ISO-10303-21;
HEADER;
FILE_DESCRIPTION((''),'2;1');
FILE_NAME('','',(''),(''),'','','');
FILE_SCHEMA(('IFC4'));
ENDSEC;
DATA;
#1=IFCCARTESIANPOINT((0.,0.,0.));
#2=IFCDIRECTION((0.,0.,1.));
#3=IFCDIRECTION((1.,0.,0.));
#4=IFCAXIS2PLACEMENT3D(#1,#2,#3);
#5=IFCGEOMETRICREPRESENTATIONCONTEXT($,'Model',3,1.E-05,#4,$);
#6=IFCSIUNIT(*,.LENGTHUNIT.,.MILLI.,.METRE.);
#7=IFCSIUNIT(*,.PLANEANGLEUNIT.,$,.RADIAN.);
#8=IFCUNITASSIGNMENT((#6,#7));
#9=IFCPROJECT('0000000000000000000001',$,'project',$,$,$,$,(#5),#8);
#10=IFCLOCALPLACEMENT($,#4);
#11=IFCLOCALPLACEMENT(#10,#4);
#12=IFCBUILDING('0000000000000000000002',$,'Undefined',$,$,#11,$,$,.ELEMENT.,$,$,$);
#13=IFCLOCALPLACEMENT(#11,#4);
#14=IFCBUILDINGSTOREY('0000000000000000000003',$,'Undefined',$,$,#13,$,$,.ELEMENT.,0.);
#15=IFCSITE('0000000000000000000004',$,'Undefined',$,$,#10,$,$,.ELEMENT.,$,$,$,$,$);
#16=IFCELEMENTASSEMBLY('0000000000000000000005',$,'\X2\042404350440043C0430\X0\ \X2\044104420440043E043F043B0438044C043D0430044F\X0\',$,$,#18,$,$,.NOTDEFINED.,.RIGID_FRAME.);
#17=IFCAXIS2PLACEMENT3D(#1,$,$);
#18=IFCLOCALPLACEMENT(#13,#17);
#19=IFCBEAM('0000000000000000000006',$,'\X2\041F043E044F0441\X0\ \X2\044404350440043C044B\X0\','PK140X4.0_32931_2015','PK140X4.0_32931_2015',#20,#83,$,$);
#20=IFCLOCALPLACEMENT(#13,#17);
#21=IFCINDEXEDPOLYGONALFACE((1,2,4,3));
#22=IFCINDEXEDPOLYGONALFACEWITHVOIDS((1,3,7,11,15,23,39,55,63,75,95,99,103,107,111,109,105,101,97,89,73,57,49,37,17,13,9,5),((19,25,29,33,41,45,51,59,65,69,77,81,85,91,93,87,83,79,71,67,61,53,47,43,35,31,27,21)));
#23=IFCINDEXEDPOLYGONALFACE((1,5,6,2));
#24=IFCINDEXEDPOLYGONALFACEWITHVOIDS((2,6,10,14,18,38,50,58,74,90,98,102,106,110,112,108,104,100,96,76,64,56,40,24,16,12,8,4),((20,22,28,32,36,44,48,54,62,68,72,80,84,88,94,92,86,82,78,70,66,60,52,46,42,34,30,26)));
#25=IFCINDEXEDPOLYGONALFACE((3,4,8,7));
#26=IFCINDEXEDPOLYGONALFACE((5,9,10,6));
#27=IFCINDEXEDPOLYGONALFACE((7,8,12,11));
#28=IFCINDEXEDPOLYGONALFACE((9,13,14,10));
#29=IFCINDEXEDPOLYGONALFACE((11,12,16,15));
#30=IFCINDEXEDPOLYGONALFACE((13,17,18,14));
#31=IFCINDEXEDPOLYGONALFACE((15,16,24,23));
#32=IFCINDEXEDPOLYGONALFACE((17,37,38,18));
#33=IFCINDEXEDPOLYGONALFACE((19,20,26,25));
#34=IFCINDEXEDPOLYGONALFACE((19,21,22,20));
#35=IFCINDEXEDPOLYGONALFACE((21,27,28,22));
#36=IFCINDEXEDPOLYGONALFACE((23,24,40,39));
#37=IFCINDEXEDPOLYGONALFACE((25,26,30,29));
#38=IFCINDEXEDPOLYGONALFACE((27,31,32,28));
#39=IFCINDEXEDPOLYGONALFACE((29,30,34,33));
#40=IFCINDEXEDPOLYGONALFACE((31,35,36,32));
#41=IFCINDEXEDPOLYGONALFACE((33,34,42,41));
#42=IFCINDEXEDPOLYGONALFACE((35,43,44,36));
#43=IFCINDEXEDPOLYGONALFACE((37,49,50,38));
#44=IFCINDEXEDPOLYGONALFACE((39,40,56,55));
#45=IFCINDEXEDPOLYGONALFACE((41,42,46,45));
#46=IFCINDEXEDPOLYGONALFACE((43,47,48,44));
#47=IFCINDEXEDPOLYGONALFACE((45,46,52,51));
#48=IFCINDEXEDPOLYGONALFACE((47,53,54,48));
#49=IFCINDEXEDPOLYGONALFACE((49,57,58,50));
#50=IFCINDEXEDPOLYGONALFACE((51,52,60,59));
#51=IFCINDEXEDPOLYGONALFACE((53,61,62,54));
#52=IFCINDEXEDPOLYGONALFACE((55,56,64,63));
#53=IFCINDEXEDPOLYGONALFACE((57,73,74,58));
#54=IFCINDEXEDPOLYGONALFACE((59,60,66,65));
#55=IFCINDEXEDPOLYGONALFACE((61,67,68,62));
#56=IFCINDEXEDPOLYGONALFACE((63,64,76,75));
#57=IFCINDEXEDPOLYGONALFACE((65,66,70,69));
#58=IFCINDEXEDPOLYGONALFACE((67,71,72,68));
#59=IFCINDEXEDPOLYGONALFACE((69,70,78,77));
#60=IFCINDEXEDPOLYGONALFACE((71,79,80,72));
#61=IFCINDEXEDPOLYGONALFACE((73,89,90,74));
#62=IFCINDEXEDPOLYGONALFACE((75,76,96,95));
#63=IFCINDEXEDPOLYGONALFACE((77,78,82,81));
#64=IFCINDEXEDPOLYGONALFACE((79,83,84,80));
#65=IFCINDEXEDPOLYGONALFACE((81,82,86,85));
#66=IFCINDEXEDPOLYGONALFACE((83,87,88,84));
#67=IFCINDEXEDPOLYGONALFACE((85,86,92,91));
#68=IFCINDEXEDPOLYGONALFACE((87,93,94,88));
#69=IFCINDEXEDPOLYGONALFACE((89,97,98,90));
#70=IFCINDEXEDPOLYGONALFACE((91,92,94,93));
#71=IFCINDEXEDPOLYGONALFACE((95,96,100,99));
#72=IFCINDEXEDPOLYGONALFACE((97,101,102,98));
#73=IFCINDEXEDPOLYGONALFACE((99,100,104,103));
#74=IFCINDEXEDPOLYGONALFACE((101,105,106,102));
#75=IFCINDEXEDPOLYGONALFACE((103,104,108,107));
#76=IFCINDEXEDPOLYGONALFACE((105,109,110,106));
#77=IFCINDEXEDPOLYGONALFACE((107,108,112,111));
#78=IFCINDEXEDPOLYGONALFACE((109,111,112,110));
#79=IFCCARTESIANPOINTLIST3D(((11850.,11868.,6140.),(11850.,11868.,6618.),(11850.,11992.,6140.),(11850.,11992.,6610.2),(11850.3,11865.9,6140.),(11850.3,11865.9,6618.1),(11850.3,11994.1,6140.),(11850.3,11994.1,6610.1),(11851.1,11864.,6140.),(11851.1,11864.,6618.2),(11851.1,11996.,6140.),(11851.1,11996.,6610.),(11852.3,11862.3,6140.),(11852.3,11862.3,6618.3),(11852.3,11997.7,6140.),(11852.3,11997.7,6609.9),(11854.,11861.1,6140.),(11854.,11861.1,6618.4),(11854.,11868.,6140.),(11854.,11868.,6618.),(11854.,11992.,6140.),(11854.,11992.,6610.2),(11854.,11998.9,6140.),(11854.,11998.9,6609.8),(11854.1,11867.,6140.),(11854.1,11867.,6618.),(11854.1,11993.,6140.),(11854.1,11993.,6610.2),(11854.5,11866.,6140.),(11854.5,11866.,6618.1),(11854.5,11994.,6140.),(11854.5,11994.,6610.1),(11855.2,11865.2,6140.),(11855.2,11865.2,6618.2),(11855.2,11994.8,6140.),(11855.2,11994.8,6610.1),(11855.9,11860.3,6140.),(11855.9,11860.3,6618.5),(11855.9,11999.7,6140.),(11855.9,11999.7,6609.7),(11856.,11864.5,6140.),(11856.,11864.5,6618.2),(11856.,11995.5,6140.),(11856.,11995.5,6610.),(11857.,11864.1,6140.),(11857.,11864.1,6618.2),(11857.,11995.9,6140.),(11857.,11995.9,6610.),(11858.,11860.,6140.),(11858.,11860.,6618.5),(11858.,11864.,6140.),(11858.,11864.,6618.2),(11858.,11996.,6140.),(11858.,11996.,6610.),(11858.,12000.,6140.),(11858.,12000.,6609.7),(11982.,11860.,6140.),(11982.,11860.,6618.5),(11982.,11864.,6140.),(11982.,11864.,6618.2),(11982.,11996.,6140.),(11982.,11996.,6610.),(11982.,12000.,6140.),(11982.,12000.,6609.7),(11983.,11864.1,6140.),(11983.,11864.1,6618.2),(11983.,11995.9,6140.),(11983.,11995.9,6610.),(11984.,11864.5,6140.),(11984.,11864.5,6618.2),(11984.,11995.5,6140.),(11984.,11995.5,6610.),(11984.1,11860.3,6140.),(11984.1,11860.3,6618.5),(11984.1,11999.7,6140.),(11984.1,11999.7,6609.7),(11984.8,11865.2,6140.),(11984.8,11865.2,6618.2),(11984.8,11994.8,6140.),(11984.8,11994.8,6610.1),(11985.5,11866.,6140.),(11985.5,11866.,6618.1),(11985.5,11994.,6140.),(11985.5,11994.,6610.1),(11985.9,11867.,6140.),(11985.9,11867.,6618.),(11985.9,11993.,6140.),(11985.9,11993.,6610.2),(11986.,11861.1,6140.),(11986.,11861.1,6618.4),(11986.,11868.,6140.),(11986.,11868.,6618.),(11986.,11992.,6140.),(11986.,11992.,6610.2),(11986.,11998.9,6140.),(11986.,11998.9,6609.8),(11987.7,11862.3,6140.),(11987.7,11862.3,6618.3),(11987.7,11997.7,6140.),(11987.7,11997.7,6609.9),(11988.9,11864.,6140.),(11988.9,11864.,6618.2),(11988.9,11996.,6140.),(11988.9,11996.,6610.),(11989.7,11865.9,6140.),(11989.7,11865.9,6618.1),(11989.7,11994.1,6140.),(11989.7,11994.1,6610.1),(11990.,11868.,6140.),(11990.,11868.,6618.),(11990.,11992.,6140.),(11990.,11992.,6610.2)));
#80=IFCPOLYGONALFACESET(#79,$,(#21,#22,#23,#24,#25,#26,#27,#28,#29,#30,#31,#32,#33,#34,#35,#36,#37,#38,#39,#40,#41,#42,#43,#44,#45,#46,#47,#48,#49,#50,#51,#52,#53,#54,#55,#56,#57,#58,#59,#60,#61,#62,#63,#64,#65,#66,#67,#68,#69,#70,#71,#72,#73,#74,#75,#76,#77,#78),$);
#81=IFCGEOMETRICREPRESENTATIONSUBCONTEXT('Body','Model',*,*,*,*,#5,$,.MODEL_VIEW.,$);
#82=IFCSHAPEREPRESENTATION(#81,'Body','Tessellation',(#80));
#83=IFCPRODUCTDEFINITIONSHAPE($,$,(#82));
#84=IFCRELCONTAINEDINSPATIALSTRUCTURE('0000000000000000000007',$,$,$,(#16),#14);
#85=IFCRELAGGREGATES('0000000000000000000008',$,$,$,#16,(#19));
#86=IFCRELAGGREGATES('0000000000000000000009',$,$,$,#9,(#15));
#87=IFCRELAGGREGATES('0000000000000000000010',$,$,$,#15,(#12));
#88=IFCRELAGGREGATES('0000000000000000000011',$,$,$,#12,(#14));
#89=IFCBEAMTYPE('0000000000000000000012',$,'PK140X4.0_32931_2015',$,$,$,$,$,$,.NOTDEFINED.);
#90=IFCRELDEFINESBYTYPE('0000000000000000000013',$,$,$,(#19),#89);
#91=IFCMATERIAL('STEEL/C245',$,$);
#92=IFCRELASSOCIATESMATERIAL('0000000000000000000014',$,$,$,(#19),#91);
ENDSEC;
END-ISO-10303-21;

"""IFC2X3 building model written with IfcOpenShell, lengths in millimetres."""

from ifc_helpers import new_model, si_unit, frame, origin_with_axes, origin_2d_with_axis, place, context, subcontext, project, spatial, hollow_rectangle, extrude, clip, halfspace, material, type_object, element, aggregate, save


model = new_model("IFC2X3")

# Units and contexts
model_context = context("Model", 3, precision=1e-05, world=origin_with_axes())
body_context = subcontext(model_context, "Body", "Model", "MODEL_VIEW")
ifc_project = project(units=[si_unit("LENGTHUNIT", "METRE", prefix="MILLI"), si_unit("PLANEANGLEUNIT", "RADIAN")], contexts=[model_context])

# Site, building, storey
site_placement = place(None, origin_with_axes())
site = spatial("IfcSite", under=ifc_project, at=site_placement, Name="Undefined", CompositionType="ELEMENT")
building_placement = place(site_placement, origin_with_axes())
building = spatial("IfcBuilding", under=site, at=building_placement, Name="Undefined", CompositionType="ELEMENT")
storey_placement = place(building_placement, origin_with_axes())
storey = spatial("IfcBuildingStorey", under=building, at=storey_placement, Name="Undefined", CompositionType="ELEMENT", Elevation=0.0)

# Shared definitions
ifc_material = material(Name="STEEL/C245")

# Element assembly
assembly_1_placement = place(storey_placement, origin_with_axes())
assembly_1 = element("IfcElementAssembly", 1, at=assembly_1_placement, inside=storey, Name="Ферма строплиьная", AssemblyPlace="NOTDEFINED", PredefinedType="RIGID_FRAME")

# Beam
beam_type_1 = type_object("IfcBeamType", Name="PK140X4.0_32931_2015", PredefinedType="NOTDEFINED")
beam_1_placement = place(assembly_1_placement, frame((11920.0, 11930.0, 6609.7), z_axis=(1.0, 0.0, 0.0), x_axis=(0.0, 0.0, -1.0)))
beam_1 = element("IfcBeam", 2, at=beam_1_placement, type_object=beam_type_1, material=ifc_material, Name="Пояс фермы", Description="PK140X4.0_32931_2015", ObjectType="PK140X4.0_32931_2015", context=body_context, shape_type="Clipping", body=[
    clip(extrude(hollow_rectangle(XDim=140.0, YDim=140.0, WallThickness=4.0, InnerFilletRadius=4.0, OuterFilletRadius=8.0, at=origin_2d_with_axis()), frame((469.7, 0.0, 0.0), z_axis=(-1.0, 0.0, 0.0), x_axis=(0.0, -1.0, 0.0)), (0.0, 0.0, 1.0), 478.5), halfspace(frame((-14.9, -167.6, 0.0), z_axis=(-0.998053, 0.062378, 0.0), x_axis=(0.0, 0.0, 1.0)), False)),
])
aggregate(assembly_1, [beam_1])

save(model, "model.ifc")
